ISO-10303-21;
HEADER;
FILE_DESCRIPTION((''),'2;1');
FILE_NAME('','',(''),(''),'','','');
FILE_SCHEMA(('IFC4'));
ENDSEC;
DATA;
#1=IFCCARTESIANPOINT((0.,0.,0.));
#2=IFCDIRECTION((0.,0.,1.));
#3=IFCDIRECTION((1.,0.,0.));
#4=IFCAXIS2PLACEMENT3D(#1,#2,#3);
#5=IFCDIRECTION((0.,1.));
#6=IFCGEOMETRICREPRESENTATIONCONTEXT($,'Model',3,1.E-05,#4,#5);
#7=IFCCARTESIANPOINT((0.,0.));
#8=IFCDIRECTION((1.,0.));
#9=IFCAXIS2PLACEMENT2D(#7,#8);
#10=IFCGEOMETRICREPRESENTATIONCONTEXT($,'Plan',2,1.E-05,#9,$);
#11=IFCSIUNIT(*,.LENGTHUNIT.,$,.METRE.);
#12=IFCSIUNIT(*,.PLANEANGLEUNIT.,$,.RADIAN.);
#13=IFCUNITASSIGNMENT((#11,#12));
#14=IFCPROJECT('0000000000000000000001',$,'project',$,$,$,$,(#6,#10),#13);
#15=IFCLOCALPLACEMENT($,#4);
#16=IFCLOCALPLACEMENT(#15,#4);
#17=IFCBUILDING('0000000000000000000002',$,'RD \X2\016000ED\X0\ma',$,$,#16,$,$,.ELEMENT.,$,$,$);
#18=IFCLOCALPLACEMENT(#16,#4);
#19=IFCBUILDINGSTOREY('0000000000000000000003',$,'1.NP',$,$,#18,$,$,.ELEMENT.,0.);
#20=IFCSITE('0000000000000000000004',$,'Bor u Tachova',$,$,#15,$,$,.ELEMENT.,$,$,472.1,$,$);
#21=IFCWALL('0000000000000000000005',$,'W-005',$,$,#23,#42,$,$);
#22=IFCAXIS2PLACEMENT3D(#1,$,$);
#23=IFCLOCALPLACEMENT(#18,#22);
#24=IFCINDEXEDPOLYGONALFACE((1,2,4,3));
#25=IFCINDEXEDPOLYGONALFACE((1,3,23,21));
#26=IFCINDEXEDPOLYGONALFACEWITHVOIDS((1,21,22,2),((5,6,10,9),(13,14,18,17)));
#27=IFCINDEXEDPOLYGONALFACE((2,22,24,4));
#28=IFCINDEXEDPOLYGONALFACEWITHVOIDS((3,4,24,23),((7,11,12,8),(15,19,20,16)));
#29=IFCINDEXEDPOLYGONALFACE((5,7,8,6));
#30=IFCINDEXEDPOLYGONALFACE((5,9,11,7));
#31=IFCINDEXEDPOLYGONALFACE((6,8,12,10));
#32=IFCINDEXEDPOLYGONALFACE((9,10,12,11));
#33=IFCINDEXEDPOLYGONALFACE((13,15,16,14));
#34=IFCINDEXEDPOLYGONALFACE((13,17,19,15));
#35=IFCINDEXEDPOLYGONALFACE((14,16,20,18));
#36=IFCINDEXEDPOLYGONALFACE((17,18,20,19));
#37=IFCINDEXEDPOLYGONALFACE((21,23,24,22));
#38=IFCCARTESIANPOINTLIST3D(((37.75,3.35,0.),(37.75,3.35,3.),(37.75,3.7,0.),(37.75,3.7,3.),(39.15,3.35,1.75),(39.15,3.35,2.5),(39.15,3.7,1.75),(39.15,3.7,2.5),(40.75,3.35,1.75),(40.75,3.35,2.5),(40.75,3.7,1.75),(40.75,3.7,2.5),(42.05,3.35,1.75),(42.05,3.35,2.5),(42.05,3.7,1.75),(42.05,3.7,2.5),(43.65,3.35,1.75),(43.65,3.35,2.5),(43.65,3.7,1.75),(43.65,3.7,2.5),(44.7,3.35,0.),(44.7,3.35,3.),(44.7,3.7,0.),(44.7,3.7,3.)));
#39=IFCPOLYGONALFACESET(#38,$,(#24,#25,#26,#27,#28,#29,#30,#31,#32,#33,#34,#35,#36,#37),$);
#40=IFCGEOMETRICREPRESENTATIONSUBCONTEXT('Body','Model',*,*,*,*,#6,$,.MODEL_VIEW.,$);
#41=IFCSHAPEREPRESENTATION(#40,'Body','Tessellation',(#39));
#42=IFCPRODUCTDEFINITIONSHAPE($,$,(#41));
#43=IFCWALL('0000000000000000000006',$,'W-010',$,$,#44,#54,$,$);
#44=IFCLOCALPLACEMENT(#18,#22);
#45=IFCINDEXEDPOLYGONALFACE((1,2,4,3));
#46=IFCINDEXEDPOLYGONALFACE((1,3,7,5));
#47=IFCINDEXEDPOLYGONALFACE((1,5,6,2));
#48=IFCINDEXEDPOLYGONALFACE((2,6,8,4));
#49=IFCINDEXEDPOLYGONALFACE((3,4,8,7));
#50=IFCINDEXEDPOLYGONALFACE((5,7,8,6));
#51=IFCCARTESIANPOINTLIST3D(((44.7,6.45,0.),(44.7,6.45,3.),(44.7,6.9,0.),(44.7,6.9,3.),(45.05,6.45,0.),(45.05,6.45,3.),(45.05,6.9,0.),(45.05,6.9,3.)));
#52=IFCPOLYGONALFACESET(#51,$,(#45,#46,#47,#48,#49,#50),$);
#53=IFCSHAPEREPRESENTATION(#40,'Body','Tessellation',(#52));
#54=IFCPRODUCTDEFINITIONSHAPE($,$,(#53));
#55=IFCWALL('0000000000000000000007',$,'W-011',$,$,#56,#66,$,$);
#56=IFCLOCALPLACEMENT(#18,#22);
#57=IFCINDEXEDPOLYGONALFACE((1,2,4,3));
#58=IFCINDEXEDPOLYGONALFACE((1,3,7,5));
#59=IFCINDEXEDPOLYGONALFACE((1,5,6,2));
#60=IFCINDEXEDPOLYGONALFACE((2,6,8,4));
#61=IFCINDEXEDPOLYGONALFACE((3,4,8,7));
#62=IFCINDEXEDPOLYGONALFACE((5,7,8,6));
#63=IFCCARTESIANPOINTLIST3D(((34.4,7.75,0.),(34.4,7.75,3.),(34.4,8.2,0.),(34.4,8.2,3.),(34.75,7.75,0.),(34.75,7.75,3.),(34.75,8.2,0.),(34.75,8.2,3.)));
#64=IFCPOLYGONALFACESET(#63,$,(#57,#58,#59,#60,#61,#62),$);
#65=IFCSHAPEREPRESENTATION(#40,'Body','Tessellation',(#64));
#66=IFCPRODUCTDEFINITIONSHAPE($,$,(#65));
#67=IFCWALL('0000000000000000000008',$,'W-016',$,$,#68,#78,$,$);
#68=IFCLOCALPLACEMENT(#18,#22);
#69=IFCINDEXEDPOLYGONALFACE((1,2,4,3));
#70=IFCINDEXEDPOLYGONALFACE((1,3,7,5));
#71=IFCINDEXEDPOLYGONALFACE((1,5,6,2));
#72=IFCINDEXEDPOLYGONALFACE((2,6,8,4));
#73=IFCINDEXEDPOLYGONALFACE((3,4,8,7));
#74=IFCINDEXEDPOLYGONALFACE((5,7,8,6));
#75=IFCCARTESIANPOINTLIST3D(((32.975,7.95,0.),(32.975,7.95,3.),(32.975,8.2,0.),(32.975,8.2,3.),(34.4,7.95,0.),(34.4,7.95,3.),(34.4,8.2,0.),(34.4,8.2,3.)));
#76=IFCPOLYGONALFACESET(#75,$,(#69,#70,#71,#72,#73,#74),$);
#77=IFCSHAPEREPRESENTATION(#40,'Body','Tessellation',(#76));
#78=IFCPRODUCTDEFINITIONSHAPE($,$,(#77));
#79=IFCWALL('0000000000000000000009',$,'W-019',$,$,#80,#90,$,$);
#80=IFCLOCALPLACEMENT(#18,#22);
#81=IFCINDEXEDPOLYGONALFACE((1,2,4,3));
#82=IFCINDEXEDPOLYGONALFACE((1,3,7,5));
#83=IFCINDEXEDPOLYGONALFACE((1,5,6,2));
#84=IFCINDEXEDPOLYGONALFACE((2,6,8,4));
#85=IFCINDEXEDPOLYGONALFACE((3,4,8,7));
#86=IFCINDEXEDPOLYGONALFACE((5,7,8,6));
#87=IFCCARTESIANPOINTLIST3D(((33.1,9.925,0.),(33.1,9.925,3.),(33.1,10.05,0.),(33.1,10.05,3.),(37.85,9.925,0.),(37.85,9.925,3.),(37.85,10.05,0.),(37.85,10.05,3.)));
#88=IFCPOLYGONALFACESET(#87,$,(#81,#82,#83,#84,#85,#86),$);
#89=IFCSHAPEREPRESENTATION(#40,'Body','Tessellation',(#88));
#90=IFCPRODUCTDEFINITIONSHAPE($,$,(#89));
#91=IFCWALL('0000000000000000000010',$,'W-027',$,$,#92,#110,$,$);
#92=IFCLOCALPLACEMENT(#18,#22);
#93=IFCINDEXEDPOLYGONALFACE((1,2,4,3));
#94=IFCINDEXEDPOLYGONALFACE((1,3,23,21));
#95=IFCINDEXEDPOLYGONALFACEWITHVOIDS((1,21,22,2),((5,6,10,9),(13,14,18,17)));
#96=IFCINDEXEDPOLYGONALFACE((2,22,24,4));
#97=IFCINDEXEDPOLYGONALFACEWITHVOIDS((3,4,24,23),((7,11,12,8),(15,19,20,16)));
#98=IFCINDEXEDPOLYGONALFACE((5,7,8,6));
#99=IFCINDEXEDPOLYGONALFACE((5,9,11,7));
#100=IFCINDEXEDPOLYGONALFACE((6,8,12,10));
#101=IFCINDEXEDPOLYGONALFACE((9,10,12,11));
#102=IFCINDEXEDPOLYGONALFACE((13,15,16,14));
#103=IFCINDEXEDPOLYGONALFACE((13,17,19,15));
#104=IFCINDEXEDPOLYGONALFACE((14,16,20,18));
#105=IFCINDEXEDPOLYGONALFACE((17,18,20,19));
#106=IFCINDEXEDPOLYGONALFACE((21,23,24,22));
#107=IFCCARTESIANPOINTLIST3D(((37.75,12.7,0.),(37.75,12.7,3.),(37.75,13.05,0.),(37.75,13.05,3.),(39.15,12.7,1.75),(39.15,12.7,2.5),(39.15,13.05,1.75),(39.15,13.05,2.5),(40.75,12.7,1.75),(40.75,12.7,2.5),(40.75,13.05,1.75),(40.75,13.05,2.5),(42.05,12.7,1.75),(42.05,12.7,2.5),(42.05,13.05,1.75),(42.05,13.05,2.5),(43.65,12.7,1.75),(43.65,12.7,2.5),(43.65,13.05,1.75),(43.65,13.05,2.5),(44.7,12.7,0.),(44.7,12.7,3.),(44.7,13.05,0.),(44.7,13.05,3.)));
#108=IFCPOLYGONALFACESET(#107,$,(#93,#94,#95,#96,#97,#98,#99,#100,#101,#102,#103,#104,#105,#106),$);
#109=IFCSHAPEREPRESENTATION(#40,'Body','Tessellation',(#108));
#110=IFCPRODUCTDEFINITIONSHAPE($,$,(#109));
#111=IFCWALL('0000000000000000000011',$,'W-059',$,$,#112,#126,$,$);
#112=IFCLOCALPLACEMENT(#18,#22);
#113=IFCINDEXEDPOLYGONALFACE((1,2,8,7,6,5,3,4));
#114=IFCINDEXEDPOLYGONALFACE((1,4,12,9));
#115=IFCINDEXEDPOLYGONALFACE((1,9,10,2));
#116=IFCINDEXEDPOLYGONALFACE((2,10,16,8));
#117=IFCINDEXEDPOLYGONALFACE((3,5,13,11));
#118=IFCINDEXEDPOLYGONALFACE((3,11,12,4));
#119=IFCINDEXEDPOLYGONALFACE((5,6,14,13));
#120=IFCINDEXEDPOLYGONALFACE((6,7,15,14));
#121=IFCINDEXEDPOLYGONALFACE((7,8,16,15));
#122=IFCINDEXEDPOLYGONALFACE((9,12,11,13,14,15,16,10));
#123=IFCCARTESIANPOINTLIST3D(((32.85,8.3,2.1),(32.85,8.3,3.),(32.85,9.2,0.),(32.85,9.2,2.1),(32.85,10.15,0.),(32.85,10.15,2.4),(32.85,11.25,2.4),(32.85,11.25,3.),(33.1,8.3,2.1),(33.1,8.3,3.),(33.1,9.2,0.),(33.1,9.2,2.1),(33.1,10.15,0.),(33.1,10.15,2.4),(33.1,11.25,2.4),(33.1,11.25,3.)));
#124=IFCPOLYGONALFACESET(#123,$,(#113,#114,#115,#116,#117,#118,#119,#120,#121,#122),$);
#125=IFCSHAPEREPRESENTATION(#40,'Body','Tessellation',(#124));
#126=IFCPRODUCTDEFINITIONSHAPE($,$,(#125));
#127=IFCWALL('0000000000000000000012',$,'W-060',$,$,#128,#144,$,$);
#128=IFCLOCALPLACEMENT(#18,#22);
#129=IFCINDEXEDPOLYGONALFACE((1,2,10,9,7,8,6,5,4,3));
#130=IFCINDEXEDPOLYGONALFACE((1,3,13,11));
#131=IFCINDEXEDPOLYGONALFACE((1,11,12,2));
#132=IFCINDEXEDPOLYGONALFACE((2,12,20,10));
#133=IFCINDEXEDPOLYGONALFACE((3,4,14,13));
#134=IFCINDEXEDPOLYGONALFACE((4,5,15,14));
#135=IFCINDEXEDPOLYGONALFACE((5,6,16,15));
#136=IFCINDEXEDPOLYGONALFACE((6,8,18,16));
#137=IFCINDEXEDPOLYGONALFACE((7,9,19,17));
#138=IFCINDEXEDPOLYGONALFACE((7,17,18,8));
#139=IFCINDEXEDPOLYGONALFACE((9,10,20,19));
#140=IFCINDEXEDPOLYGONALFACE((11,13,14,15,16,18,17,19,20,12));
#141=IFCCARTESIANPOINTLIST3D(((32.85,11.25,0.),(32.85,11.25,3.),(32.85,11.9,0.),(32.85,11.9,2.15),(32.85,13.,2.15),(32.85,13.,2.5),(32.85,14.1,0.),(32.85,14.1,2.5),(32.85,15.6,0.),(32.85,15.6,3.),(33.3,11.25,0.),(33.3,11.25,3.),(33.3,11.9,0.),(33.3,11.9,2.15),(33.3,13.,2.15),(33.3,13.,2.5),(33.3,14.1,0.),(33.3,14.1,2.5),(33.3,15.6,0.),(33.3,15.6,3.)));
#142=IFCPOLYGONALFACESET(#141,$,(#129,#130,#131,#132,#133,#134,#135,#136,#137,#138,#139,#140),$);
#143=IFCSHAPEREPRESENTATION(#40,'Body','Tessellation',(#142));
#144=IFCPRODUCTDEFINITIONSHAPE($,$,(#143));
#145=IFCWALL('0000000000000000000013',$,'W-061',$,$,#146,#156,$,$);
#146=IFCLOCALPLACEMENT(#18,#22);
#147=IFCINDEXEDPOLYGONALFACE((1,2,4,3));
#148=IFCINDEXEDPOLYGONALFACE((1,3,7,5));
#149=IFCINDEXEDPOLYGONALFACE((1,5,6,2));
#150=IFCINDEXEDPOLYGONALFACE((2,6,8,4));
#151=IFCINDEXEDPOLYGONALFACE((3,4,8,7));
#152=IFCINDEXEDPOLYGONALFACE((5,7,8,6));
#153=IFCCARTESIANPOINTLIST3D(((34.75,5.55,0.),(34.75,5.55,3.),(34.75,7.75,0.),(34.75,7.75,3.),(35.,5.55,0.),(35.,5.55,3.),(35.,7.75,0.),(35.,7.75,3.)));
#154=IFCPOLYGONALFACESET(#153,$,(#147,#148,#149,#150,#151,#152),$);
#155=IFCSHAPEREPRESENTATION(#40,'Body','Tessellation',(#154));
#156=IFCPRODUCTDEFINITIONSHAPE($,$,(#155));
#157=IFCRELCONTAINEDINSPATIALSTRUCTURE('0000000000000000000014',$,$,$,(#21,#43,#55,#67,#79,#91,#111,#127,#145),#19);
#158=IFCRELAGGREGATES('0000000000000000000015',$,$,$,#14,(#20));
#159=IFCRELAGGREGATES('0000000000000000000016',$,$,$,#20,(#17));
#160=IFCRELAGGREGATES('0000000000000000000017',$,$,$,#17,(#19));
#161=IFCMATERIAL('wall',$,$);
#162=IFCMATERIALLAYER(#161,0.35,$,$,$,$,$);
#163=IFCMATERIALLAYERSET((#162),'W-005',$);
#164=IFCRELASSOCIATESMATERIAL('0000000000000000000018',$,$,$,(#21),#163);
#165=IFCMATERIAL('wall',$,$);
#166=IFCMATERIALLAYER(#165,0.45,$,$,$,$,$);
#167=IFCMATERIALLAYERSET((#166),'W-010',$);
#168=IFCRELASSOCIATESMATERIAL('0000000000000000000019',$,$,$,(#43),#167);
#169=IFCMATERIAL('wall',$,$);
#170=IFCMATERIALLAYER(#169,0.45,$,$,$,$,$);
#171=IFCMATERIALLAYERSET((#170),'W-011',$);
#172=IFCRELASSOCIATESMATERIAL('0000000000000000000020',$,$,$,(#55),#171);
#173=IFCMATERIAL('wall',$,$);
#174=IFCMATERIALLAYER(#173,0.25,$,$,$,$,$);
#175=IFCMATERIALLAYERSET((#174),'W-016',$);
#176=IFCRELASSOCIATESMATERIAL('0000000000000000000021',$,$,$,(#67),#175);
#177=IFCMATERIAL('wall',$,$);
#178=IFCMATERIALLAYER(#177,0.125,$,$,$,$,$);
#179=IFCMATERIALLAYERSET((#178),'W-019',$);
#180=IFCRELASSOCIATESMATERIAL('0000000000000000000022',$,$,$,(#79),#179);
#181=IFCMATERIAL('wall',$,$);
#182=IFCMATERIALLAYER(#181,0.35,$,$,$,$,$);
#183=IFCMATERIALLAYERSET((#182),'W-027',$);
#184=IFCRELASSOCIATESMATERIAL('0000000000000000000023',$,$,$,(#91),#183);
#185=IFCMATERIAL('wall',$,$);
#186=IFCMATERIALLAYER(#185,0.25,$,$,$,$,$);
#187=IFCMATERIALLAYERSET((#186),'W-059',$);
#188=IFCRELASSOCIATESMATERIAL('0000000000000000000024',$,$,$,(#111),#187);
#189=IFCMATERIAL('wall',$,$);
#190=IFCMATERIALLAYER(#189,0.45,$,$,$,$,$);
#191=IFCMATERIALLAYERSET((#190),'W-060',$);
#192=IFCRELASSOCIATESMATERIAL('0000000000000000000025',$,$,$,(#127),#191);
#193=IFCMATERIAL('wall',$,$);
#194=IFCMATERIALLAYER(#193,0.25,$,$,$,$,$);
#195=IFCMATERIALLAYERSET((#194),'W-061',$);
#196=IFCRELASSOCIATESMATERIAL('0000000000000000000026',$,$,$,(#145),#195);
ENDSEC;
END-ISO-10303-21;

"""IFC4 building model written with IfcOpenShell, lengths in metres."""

from ifc_helpers import new_model, si_unit, direction, frame, frame_2d, origin_with_axes, origin_2d_with_axis, place, context, subcontext, project, spatial, line, indexed_curve, rectangle, outline, extrude, material, layer, layer_set, layer_usage, element, save


model = new_model("IFC4")

# Units and contexts
model_context = context("Model", 3, precision=1e-05, world=origin_with_axes(), true_north=direction((0.0, 1.0)))
plan_context = context("Plan", 2, precision=1e-05, world=origin_2d_with_axis())
body_context = subcontext(model_context, "Body", "Model", "MODEL_VIEW")
ifc_project = project(units=[si_unit("LENGTHUNIT", "METRE"), si_unit("PLANEANGLEUNIT", "RADIAN")], contexts=[model_context, plan_context])

# Site, building, storey
site_placement = place(None, origin_with_axes())
site = spatial("IfcSite", under=ifc_project, at=site_placement, Name="Bor u Tachova", CompositionType="ELEMENT", RefElevation=472.1)
building_placement = place(site_placement, origin_with_axes())
building = spatial("IfcBuilding", under=site, at=building_placement, Name="RD Šíma", CompositionType="ELEMENT")
storey_placement = place(building_placement, origin_with_axes())
storey = spatial("IfcBuildingStorey", under=building, at=storey_placement, Name="1.NP", CompositionType="ELEMENT", Elevation=0.0)

# Wall, openings
ifc_material_1 = material(Name="wall")
ifc_layer_1 = layer(ifc_material_1, 0.35)
ifc_layer_set_1 = layer_set([ifc_layer_1], Name="W-005")
ifc_layer_usage_1 = layer_usage(ifc_layer_set_1, "AXIS2", "POSITIVE", -0.175)
wall_1_placement = place(storey_placement, frame((37.925, 3.525, 0.0), z_axis=(0.0, 0.0, 1.0), x_axis=(1.0, 0.0, 0.0)))
wall_1 = element("IfcWall", 1, at=wall_1_placement, inside=storey, material=ifc_layer_usage_1, Name="W-005", context=body_context, shape_type="SweptSolid", body=[
    extrude(outline(indexed_curve([(-0.175, -0.175), (-0.175, 0.175), (0.175, 0.175), (6.775, 0.175), (6.775, -0.175)], segments=[line(1, 2, 3, 4, 5, 1)])), origin_with_axes(), (0.0, 0.0, 1.0), 3.0),
])
opening_1_placement = place(wall_1_placement, frame((1.225, 0.0, 1.75), z_axis=(0.0, 0.0, 1.0), x_axis=(1.0, 0.0, 0.0)))
element("IfcOpeningElement", 2, at=opening_1_placement, cuts=wall_1, PredefinedType="OPENING", context=body_context, shape_type="SweptSolid", body=[
    extrude(rectangle(XDim=1.6, YDim=0.35, at=frame_2d((0.8, 0.0))), origin_with_axes(), (0.0, 0.0, 1.0), 0.75),
])
opening_2_placement = place(wall_1_placement, frame((4.125, 0.0, 1.75), z_axis=(0.0, 0.0, 1.0), x_axis=(1.0, 0.0, 0.0)))
element("IfcOpeningElement", 3, at=opening_2_placement, cuts=wall_1, PredefinedType="OPENING", context=body_context, shape_type="SweptSolid", body=[
    extrude(rectangle(XDim=1.6, YDim=0.35, at=frame_2d((0.8, 0.0))), origin_with_axes(), (0.0, 0.0, 1.0), 0.75),
])

# Walls
ifc_material_2 = material(Name="wall")
ifc_layer_2 = layer(ifc_material_2, 0.45)
ifc_layer_set_2 = layer_set([ifc_layer_2], Name="W-010")
ifc_layer_usage_2 = layer_usage(ifc_layer_set_2, "AXIS2", "POSITIVE", -0.225)
wall_2_placement = place(storey_placement, frame((44.7, 6.675, 0.0), z_axis=(0.0, 0.0, 1.0), x_axis=(1.0, 0.0, 0.0)))
element("IfcWall", 4, at=wall_2_placement, inside=storey, material=ifc_layer_usage_2, Name="W-010", context=body_context, shape_type="SweptSolid", body=[
    extrude(rectangle(XDim=0.35, YDim=0.45, at=frame_2d((0.175, 0.0))), origin_with_axes(), (0.0, 0.0, 1.0), 3.0),
])
ifc_material_3 = material(Name="wall")
ifc_layer_3 = layer(ifc_material_3, 0.45)
ifc_layer_set_3 = layer_set([ifc_layer_3], Name="W-011")
ifc_layer_usage_3 = layer_usage(ifc_layer_set_3, "AXIS2", "POSITIVE", -0.225)
wall_3_placement = place(storey_placement, frame((34.4, 7.975, 0.0), z_axis=(0.0, 0.0, 1.0), x_axis=(1.0, 0.0, 0.0)))
element("IfcWall", 5, at=wall_3_placement, inside=storey, material=ifc_layer_usage_3, Name="W-011", context=body_context, shape_type="SweptSolid", body=[
    extrude(rectangle(XDim=0.35, YDim=0.45, at=frame_2d((0.175, 0.0))), origin_with_axes(), (0.0, 0.0, 1.0), 3.0),
])
ifc_material_4 = material(Name="wall")
ifc_layer_4 = layer(ifc_material_4, 0.25)
ifc_layer_set_4 = layer_set([ifc_layer_4], Name="W-016")
ifc_layer_usage_4 = layer_usage(ifc_layer_set_4, "AXIS2", "POSITIVE", -0.125)
wall_4_placement = place(storey_placement, frame((32.975, 8.075, 0.0), z_axis=(0.0, 0.0, 1.0), x_axis=(1.0, 0.0, 0.0)))
element("IfcWall", 6, at=wall_4_placement, inside=storey, material=ifc_layer_usage_4, Name="W-016", context=body_context, shape_type="SweptSolid", body=[
    extrude(rectangle(XDim=1.425, YDim=0.25, at=frame_2d((0.7125, 0.0))), origin_with_axes(), (0.0, 0.0, 1.0), 3.0),
])
ifc_material_5 = material(Name="wall")
ifc_layer_5 = layer(ifc_material_5, 0.125)
ifc_layer_set_5 = layer_set([ifc_layer_5], Name="W-019")
ifc_layer_usage_5 = layer_usage(ifc_layer_set_5, "AXIS2", "POSITIVE", -0.0625)
wall_5_placement = place(storey_placement, frame((32.975, 9.9875, 0.0), z_axis=(0.0, 0.0, 1.0), x_axis=(1.0, 0.0, 0.0)))
element("IfcWall", 7, at=wall_5_placement, inside=storey, material=ifc_layer_usage_5, Name="W-019", context=body_context, shape_type="SweptSolid", body=[
    extrude(outline(indexed_curve([(0.125, -0.0625), (0.125, 0.0625), (4.875, 0.0625), (4.875, -0.0625)], segments=[line(1, 2, 3, 4, 1)])), origin_with_axes(), (0.0, 0.0, 1.0), 3.0),
])

# Walls, openings
ifc_material_6 = material(Name="wall")
ifc_layer_6 = layer(ifc_material_6, 0.35)
ifc_layer_set_6 = layer_set([ifc_layer_6], Name="W-027")
ifc_layer_usage_6 = layer_usage(ifc_layer_set_6, "AXIS2", "POSITIVE", -0.175)
wall_6_placement = place(storey_placement, frame((37.925, 12.875, 0.0), z_axis=(0.0, 0.0, 1.0), x_axis=(1.0, 0.0, 0.0)))
wall_6 = element("IfcWall", 8, at=wall_6_placement, inside=storey, material=ifc_layer_usage_6, Name="W-027", context=body_context, shape_type="SweptSolid", body=[
    extrude(outline(indexed_curve([(0.175, -0.175), (-0.175, -0.175), (-0.175, 0.175), (6.775, 0.175), (6.775, -0.175)], segments=[line(1, 2, 3, 4, 5, 1)])), origin_with_axes(), (0.0, 0.0, 1.0), 3.0),
])
opening_3_placement = place(wall_6_placement, frame((1.225, 0.0, 1.75), z_axis=(0.0, 0.0, 1.0), x_axis=(1.0, 0.0, 0.0)))
element("IfcOpeningElement", 9, at=opening_3_placement, cuts=wall_6, PredefinedType="OPENING", context=body_context, shape_type="SweptSolid", body=[
    extrude(rectangle(XDim=1.6, YDim=0.35, at=frame_2d((0.8, 0.0))), origin_with_axes(), (0.0, 0.0, 1.0), 0.75),
])
opening_4_placement = place(wall_6_placement, frame((4.125, 0.0, 1.75), z_axis=(0.0, 0.0, 1.0), x_axis=(1.0, 0.0, 0.0)))
element("IfcOpeningElement", 10, at=opening_4_placement, cuts=wall_6, PredefinedType="OPENING", context=body_context, shape_type="SweptSolid", body=[
    extrude(rectangle(XDim=1.6, YDim=0.35, at=frame_2d((0.8, 0.0))), origin_with_axes(), (0.0, 0.0, 1.0), 0.75),
])
ifc_material_7 = material(Name="wall")
ifc_layer_7 = layer(ifc_material_7, 0.25)
ifc_layer_set_7 = layer_set([ifc_layer_7], Name="W-059")
ifc_layer_usage_7 = layer_usage(ifc_layer_set_7, "AXIS2", "POSITIVE", -0.125)
wall_7_placement = place(storey_placement, frame((32.975, 8.3, 0.0), z_axis=(0.0, 0.0, 1.0), x_axis=(0.0, 1.0, 0.0)))
wall_7 = element("IfcWall", 11, at=wall_7_placement, inside=storey, material=ifc_layer_usage_7, Name="W-059", context=body_context, shape_type="SweptSolid", body=[
    extrude(outline(indexed_curve([(0.0, -0.125), (0.0, 0.125), (2.95, 0.125), (2.95, -0.125)], segments=[line(1, 2, 3, 4, 1)])), origin_with_axes(), (0.0, 0.0, 1.0), 3.0),
])
opening_5_placement = place(wall_7_placement, origin_with_axes())
element("IfcOpeningElement", 12, at=opening_5_placement, cuts=wall_7, PredefinedType="OPENING", context=body_context, shape_type="SweptSolid", body=[
    extrude(rectangle(XDim=0.9, YDim=0.25, at=frame_2d((0.45, 0.0))), origin_with_axes(), (0.0, 0.0, 1.0), 2.1),
])
opening_6_placement = place(wall_7_placement, frame((1.85, 0.0, 0.0), z_axis=(0.0, 0.0, 1.0), x_axis=(1.0, 0.0, 0.0)))
element("IfcOpeningElement", 13, at=opening_6_placement, cuts=wall_7, PredefinedType="OPENING", context=body_context, shape_type="SweptSolid", body=[
    extrude(rectangle(XDim=1.1, YDim=0.25, at=frame_2d((0.55, 0.0))), origin_with_axes(), (0.0, 0.0, 1.0), 2.4),
])
ifc_material_8 = material(Name="wall")
ifc_layer_8 = layer(ifc_material_8, 0.45)
ifc_layer_set_8 = layer_set([ifc_layer_8], Name="W-060")
ifc_layer_usage_8 = layer_usage(ifc_layer_set_8, "AXIS2", "POSITIVE", -0.225)
wall_8_placement = place(storey_placement, frame((33.075, 11.425, 0.0), z_axis=(0.0, 0.0, 1.0), x_axis=(0.0, 1.0, 0.0)))
wall_8 = element("IfcWall", 14, at=wall_8_placement, inside=storey, material=ifc_layer_usage_8, Name="W-060", context=body_context, shape_type="SweptSolid", body=[
    extrude(outline(indexed_curve([(0.175, -0.225), (-0.175, -0.225), (-0.175, 0.225), (4.175, 0.225), (4.175, -0.225)], segments=[line(1, 2, 3, 4, 5, 1)])), origin_with_axes(), (0.0, 0.0, 1.0), 3.0),
])
opening_7_placement = place(wall_8_placement, frame((0.475, 0.0, 0.0), z_axis=(0.0, 0.0, 1.0), x_axis=(1.0, 0.0, 0.0)))
element("IfcOpeningElement", 15, at=opening_7_placement, cuts=wall_8, PredefinedType="OPENING", context=body_context, shape_type="SweptSolid", body=[
    extrude(rectangle(XDim=1.1, YDim=0.45, at=frame_2d((0.55, 0.0))), origin_with_axes(), (0.0, 0.0, 1.0), 2.15),
])
opening_8_placement = place(wall_8_placement, frame((1.575, 0.0, 0.0), z_axis=(0.0, 0.0, 1.0), x_axis=(1.0, 0.0, 0.0)))
element("IfcOpeningElement", 16, at=opening_8_placement, cuts=wall_8, PredefinedType="OPENING", context=body_context, shape_type="SweptSolid", body=[
    extrude(rectangle(XDim=1.1, YDim=0.45, at=frame_2d((0.55, 0.0))), origin_with_axes(), (0.0, 0.0, 1.0), 2.5),
])

# Wall
ifc_material_9 = material(Name="wall")
ifc_layer_9 = layer(ifc_material_9, 0.25)
ifc_layer_set_9 = layer_set([ifc_layer_9], Name="W-061")
ifc_layer_usage_9 = layer_usage(ifc_layer_set_9, "AXIS2", "POSITIVE", -0.125)
wall_9_placement = place(storey_placement, frame((34.875, 5.55, 0.0), z_axis=(0.0, 0.0, 1.0), x_axis=(0.0, 1.0, 0.0)))
element("IfcWall", 17, at=wall_9_placement, inside=storey, material=ifc_layer_usage_9, Name="W-061", context=body_context, shape_type="SweptSolid", body=[
    extrude(rectangle(XDim=2.2, YDim=0.25, at=frame_2d((1.1, 0.0))), origin_with_axes(), (0.0, 0.0, 1.0), 3.0),
])

save(model, "model.ifc")
